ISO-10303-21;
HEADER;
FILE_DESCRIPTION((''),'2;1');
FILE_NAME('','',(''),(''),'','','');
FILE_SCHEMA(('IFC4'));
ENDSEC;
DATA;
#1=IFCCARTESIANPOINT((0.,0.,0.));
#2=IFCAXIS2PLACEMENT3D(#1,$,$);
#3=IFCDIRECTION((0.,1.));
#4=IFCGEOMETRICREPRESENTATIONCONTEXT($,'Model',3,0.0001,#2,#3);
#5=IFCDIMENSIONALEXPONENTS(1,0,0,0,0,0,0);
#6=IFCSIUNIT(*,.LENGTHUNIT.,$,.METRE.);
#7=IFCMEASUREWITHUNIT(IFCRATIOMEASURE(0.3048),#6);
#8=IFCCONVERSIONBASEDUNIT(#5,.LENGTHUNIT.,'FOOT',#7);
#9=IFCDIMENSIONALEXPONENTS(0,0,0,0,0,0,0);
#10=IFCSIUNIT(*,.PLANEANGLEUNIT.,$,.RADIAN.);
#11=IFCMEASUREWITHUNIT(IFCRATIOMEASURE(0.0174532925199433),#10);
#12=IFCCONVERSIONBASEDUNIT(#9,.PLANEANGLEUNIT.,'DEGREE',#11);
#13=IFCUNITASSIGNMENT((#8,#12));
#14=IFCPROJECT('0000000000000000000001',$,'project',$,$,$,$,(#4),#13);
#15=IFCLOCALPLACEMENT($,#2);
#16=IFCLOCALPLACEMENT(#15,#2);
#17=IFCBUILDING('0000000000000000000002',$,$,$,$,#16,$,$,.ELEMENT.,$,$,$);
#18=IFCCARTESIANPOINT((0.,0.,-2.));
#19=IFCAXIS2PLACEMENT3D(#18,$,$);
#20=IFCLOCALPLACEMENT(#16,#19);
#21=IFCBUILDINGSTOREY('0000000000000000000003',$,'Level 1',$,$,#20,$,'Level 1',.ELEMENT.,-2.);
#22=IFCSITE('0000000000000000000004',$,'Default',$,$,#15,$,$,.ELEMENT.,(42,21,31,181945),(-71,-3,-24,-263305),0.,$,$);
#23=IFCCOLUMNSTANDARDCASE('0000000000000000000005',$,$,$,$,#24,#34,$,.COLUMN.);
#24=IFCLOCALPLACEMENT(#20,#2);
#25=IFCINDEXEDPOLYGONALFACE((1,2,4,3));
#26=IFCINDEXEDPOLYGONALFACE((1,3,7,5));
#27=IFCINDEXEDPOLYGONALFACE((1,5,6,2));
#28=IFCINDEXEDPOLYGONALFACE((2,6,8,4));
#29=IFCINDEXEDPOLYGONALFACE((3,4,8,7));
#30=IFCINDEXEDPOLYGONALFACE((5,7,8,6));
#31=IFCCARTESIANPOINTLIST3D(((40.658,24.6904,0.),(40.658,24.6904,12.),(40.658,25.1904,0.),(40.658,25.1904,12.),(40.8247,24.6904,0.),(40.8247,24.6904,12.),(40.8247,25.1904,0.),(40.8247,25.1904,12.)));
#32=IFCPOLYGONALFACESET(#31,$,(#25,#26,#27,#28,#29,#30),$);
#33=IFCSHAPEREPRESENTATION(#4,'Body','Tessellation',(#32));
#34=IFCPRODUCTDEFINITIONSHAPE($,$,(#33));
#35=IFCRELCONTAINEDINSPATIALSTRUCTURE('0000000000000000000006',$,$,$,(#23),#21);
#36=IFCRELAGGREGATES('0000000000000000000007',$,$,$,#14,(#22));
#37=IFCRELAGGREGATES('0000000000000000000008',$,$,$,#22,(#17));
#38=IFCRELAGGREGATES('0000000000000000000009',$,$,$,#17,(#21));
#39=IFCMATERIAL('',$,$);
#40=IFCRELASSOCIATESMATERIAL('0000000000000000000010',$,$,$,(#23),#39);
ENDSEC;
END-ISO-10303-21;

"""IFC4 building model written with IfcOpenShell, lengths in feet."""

from ifc_helpers import new_model, entity, si_unit, converted_unit, direction, frame, origin, place, context, project, spatial, rectangle, extrude, material, element, save


model = new_model("IFC4")

# Units and contexts
model_context = context("Model", 3, precision=0.0001, world=origin(), true_north=direction((0.0, 1.0)))
ifc_project = project(units=[converted_unit("LENGTHUNIT", "FOOT", entity("IfcRatioMeasure", 0.3048), si_unit("LENGTHUNIT", "METRE"), dimensions=[1, 0, 0, 0, 0, 0, 0]), converted_unit("PLANEANGLEUNIT", "DEGREE", entity("IfcRatioMeasure", 0.0174532925199433), si_unit("PLANEANGLEUNIT", "RADIAN"), dimensions=[0, 0, 0, 0, 0, 0, 0])], contexts=[model_context])

# Site, building, storey
site_placement = place(None, origin())
site = spatial("IfcSite", under=ifc_project, at=site_placement, Name="Default", CompositionType="ELEMENT", RefLatitude=(42, 21, 31, 181945), RefLongitude=(-71, -3, -24, -263305), RefElevation=0.0)
building_placement = place(site_placement, origin())
building = spatial("IfcBuilding", under=site, at=building_placement, CompositionType="ELEMENT")
storey_placement = place(building_placement, frame((0.0, 0.0, -2.0)))
storey = spatial("IfcBuildingStorey", under=building, at=storey_placement, Name="Level 1", LongName="Level 1", CompositionType="ELEMENT", Elevation=-2.0)

# Column
ifc_material_1 = material(Name="")
wall_placement = place(storey_placement, frame((40.8247, 24.9404, 0.0), z_axis=(0.0, 0.0, 1.0), x_axis=(-1.0, 0.0, 0.0)))
for number, where, z_axis, x_axis in (
    (1, (0.0833, 0.0, 0.0), (0.0, 0.0, 1.0), (1.0, 0.0, 0.0)),
):
    element("IfcColumnStandardCase", number, at=place(wall_placement, frame(where, z_axis=z_axis, x_axis=x_axis)), inside=storey, material=ifc_material_1, PredefinedType="COLUMN", context=model_context, shape_type="SweptSolid", body=[
        extrude(rectangle(XDim=0.1667, YDim=0.5), origin(), (0.0, 0.0, 1.0), 12.0),
    ])

save(model, "model.ifc")
